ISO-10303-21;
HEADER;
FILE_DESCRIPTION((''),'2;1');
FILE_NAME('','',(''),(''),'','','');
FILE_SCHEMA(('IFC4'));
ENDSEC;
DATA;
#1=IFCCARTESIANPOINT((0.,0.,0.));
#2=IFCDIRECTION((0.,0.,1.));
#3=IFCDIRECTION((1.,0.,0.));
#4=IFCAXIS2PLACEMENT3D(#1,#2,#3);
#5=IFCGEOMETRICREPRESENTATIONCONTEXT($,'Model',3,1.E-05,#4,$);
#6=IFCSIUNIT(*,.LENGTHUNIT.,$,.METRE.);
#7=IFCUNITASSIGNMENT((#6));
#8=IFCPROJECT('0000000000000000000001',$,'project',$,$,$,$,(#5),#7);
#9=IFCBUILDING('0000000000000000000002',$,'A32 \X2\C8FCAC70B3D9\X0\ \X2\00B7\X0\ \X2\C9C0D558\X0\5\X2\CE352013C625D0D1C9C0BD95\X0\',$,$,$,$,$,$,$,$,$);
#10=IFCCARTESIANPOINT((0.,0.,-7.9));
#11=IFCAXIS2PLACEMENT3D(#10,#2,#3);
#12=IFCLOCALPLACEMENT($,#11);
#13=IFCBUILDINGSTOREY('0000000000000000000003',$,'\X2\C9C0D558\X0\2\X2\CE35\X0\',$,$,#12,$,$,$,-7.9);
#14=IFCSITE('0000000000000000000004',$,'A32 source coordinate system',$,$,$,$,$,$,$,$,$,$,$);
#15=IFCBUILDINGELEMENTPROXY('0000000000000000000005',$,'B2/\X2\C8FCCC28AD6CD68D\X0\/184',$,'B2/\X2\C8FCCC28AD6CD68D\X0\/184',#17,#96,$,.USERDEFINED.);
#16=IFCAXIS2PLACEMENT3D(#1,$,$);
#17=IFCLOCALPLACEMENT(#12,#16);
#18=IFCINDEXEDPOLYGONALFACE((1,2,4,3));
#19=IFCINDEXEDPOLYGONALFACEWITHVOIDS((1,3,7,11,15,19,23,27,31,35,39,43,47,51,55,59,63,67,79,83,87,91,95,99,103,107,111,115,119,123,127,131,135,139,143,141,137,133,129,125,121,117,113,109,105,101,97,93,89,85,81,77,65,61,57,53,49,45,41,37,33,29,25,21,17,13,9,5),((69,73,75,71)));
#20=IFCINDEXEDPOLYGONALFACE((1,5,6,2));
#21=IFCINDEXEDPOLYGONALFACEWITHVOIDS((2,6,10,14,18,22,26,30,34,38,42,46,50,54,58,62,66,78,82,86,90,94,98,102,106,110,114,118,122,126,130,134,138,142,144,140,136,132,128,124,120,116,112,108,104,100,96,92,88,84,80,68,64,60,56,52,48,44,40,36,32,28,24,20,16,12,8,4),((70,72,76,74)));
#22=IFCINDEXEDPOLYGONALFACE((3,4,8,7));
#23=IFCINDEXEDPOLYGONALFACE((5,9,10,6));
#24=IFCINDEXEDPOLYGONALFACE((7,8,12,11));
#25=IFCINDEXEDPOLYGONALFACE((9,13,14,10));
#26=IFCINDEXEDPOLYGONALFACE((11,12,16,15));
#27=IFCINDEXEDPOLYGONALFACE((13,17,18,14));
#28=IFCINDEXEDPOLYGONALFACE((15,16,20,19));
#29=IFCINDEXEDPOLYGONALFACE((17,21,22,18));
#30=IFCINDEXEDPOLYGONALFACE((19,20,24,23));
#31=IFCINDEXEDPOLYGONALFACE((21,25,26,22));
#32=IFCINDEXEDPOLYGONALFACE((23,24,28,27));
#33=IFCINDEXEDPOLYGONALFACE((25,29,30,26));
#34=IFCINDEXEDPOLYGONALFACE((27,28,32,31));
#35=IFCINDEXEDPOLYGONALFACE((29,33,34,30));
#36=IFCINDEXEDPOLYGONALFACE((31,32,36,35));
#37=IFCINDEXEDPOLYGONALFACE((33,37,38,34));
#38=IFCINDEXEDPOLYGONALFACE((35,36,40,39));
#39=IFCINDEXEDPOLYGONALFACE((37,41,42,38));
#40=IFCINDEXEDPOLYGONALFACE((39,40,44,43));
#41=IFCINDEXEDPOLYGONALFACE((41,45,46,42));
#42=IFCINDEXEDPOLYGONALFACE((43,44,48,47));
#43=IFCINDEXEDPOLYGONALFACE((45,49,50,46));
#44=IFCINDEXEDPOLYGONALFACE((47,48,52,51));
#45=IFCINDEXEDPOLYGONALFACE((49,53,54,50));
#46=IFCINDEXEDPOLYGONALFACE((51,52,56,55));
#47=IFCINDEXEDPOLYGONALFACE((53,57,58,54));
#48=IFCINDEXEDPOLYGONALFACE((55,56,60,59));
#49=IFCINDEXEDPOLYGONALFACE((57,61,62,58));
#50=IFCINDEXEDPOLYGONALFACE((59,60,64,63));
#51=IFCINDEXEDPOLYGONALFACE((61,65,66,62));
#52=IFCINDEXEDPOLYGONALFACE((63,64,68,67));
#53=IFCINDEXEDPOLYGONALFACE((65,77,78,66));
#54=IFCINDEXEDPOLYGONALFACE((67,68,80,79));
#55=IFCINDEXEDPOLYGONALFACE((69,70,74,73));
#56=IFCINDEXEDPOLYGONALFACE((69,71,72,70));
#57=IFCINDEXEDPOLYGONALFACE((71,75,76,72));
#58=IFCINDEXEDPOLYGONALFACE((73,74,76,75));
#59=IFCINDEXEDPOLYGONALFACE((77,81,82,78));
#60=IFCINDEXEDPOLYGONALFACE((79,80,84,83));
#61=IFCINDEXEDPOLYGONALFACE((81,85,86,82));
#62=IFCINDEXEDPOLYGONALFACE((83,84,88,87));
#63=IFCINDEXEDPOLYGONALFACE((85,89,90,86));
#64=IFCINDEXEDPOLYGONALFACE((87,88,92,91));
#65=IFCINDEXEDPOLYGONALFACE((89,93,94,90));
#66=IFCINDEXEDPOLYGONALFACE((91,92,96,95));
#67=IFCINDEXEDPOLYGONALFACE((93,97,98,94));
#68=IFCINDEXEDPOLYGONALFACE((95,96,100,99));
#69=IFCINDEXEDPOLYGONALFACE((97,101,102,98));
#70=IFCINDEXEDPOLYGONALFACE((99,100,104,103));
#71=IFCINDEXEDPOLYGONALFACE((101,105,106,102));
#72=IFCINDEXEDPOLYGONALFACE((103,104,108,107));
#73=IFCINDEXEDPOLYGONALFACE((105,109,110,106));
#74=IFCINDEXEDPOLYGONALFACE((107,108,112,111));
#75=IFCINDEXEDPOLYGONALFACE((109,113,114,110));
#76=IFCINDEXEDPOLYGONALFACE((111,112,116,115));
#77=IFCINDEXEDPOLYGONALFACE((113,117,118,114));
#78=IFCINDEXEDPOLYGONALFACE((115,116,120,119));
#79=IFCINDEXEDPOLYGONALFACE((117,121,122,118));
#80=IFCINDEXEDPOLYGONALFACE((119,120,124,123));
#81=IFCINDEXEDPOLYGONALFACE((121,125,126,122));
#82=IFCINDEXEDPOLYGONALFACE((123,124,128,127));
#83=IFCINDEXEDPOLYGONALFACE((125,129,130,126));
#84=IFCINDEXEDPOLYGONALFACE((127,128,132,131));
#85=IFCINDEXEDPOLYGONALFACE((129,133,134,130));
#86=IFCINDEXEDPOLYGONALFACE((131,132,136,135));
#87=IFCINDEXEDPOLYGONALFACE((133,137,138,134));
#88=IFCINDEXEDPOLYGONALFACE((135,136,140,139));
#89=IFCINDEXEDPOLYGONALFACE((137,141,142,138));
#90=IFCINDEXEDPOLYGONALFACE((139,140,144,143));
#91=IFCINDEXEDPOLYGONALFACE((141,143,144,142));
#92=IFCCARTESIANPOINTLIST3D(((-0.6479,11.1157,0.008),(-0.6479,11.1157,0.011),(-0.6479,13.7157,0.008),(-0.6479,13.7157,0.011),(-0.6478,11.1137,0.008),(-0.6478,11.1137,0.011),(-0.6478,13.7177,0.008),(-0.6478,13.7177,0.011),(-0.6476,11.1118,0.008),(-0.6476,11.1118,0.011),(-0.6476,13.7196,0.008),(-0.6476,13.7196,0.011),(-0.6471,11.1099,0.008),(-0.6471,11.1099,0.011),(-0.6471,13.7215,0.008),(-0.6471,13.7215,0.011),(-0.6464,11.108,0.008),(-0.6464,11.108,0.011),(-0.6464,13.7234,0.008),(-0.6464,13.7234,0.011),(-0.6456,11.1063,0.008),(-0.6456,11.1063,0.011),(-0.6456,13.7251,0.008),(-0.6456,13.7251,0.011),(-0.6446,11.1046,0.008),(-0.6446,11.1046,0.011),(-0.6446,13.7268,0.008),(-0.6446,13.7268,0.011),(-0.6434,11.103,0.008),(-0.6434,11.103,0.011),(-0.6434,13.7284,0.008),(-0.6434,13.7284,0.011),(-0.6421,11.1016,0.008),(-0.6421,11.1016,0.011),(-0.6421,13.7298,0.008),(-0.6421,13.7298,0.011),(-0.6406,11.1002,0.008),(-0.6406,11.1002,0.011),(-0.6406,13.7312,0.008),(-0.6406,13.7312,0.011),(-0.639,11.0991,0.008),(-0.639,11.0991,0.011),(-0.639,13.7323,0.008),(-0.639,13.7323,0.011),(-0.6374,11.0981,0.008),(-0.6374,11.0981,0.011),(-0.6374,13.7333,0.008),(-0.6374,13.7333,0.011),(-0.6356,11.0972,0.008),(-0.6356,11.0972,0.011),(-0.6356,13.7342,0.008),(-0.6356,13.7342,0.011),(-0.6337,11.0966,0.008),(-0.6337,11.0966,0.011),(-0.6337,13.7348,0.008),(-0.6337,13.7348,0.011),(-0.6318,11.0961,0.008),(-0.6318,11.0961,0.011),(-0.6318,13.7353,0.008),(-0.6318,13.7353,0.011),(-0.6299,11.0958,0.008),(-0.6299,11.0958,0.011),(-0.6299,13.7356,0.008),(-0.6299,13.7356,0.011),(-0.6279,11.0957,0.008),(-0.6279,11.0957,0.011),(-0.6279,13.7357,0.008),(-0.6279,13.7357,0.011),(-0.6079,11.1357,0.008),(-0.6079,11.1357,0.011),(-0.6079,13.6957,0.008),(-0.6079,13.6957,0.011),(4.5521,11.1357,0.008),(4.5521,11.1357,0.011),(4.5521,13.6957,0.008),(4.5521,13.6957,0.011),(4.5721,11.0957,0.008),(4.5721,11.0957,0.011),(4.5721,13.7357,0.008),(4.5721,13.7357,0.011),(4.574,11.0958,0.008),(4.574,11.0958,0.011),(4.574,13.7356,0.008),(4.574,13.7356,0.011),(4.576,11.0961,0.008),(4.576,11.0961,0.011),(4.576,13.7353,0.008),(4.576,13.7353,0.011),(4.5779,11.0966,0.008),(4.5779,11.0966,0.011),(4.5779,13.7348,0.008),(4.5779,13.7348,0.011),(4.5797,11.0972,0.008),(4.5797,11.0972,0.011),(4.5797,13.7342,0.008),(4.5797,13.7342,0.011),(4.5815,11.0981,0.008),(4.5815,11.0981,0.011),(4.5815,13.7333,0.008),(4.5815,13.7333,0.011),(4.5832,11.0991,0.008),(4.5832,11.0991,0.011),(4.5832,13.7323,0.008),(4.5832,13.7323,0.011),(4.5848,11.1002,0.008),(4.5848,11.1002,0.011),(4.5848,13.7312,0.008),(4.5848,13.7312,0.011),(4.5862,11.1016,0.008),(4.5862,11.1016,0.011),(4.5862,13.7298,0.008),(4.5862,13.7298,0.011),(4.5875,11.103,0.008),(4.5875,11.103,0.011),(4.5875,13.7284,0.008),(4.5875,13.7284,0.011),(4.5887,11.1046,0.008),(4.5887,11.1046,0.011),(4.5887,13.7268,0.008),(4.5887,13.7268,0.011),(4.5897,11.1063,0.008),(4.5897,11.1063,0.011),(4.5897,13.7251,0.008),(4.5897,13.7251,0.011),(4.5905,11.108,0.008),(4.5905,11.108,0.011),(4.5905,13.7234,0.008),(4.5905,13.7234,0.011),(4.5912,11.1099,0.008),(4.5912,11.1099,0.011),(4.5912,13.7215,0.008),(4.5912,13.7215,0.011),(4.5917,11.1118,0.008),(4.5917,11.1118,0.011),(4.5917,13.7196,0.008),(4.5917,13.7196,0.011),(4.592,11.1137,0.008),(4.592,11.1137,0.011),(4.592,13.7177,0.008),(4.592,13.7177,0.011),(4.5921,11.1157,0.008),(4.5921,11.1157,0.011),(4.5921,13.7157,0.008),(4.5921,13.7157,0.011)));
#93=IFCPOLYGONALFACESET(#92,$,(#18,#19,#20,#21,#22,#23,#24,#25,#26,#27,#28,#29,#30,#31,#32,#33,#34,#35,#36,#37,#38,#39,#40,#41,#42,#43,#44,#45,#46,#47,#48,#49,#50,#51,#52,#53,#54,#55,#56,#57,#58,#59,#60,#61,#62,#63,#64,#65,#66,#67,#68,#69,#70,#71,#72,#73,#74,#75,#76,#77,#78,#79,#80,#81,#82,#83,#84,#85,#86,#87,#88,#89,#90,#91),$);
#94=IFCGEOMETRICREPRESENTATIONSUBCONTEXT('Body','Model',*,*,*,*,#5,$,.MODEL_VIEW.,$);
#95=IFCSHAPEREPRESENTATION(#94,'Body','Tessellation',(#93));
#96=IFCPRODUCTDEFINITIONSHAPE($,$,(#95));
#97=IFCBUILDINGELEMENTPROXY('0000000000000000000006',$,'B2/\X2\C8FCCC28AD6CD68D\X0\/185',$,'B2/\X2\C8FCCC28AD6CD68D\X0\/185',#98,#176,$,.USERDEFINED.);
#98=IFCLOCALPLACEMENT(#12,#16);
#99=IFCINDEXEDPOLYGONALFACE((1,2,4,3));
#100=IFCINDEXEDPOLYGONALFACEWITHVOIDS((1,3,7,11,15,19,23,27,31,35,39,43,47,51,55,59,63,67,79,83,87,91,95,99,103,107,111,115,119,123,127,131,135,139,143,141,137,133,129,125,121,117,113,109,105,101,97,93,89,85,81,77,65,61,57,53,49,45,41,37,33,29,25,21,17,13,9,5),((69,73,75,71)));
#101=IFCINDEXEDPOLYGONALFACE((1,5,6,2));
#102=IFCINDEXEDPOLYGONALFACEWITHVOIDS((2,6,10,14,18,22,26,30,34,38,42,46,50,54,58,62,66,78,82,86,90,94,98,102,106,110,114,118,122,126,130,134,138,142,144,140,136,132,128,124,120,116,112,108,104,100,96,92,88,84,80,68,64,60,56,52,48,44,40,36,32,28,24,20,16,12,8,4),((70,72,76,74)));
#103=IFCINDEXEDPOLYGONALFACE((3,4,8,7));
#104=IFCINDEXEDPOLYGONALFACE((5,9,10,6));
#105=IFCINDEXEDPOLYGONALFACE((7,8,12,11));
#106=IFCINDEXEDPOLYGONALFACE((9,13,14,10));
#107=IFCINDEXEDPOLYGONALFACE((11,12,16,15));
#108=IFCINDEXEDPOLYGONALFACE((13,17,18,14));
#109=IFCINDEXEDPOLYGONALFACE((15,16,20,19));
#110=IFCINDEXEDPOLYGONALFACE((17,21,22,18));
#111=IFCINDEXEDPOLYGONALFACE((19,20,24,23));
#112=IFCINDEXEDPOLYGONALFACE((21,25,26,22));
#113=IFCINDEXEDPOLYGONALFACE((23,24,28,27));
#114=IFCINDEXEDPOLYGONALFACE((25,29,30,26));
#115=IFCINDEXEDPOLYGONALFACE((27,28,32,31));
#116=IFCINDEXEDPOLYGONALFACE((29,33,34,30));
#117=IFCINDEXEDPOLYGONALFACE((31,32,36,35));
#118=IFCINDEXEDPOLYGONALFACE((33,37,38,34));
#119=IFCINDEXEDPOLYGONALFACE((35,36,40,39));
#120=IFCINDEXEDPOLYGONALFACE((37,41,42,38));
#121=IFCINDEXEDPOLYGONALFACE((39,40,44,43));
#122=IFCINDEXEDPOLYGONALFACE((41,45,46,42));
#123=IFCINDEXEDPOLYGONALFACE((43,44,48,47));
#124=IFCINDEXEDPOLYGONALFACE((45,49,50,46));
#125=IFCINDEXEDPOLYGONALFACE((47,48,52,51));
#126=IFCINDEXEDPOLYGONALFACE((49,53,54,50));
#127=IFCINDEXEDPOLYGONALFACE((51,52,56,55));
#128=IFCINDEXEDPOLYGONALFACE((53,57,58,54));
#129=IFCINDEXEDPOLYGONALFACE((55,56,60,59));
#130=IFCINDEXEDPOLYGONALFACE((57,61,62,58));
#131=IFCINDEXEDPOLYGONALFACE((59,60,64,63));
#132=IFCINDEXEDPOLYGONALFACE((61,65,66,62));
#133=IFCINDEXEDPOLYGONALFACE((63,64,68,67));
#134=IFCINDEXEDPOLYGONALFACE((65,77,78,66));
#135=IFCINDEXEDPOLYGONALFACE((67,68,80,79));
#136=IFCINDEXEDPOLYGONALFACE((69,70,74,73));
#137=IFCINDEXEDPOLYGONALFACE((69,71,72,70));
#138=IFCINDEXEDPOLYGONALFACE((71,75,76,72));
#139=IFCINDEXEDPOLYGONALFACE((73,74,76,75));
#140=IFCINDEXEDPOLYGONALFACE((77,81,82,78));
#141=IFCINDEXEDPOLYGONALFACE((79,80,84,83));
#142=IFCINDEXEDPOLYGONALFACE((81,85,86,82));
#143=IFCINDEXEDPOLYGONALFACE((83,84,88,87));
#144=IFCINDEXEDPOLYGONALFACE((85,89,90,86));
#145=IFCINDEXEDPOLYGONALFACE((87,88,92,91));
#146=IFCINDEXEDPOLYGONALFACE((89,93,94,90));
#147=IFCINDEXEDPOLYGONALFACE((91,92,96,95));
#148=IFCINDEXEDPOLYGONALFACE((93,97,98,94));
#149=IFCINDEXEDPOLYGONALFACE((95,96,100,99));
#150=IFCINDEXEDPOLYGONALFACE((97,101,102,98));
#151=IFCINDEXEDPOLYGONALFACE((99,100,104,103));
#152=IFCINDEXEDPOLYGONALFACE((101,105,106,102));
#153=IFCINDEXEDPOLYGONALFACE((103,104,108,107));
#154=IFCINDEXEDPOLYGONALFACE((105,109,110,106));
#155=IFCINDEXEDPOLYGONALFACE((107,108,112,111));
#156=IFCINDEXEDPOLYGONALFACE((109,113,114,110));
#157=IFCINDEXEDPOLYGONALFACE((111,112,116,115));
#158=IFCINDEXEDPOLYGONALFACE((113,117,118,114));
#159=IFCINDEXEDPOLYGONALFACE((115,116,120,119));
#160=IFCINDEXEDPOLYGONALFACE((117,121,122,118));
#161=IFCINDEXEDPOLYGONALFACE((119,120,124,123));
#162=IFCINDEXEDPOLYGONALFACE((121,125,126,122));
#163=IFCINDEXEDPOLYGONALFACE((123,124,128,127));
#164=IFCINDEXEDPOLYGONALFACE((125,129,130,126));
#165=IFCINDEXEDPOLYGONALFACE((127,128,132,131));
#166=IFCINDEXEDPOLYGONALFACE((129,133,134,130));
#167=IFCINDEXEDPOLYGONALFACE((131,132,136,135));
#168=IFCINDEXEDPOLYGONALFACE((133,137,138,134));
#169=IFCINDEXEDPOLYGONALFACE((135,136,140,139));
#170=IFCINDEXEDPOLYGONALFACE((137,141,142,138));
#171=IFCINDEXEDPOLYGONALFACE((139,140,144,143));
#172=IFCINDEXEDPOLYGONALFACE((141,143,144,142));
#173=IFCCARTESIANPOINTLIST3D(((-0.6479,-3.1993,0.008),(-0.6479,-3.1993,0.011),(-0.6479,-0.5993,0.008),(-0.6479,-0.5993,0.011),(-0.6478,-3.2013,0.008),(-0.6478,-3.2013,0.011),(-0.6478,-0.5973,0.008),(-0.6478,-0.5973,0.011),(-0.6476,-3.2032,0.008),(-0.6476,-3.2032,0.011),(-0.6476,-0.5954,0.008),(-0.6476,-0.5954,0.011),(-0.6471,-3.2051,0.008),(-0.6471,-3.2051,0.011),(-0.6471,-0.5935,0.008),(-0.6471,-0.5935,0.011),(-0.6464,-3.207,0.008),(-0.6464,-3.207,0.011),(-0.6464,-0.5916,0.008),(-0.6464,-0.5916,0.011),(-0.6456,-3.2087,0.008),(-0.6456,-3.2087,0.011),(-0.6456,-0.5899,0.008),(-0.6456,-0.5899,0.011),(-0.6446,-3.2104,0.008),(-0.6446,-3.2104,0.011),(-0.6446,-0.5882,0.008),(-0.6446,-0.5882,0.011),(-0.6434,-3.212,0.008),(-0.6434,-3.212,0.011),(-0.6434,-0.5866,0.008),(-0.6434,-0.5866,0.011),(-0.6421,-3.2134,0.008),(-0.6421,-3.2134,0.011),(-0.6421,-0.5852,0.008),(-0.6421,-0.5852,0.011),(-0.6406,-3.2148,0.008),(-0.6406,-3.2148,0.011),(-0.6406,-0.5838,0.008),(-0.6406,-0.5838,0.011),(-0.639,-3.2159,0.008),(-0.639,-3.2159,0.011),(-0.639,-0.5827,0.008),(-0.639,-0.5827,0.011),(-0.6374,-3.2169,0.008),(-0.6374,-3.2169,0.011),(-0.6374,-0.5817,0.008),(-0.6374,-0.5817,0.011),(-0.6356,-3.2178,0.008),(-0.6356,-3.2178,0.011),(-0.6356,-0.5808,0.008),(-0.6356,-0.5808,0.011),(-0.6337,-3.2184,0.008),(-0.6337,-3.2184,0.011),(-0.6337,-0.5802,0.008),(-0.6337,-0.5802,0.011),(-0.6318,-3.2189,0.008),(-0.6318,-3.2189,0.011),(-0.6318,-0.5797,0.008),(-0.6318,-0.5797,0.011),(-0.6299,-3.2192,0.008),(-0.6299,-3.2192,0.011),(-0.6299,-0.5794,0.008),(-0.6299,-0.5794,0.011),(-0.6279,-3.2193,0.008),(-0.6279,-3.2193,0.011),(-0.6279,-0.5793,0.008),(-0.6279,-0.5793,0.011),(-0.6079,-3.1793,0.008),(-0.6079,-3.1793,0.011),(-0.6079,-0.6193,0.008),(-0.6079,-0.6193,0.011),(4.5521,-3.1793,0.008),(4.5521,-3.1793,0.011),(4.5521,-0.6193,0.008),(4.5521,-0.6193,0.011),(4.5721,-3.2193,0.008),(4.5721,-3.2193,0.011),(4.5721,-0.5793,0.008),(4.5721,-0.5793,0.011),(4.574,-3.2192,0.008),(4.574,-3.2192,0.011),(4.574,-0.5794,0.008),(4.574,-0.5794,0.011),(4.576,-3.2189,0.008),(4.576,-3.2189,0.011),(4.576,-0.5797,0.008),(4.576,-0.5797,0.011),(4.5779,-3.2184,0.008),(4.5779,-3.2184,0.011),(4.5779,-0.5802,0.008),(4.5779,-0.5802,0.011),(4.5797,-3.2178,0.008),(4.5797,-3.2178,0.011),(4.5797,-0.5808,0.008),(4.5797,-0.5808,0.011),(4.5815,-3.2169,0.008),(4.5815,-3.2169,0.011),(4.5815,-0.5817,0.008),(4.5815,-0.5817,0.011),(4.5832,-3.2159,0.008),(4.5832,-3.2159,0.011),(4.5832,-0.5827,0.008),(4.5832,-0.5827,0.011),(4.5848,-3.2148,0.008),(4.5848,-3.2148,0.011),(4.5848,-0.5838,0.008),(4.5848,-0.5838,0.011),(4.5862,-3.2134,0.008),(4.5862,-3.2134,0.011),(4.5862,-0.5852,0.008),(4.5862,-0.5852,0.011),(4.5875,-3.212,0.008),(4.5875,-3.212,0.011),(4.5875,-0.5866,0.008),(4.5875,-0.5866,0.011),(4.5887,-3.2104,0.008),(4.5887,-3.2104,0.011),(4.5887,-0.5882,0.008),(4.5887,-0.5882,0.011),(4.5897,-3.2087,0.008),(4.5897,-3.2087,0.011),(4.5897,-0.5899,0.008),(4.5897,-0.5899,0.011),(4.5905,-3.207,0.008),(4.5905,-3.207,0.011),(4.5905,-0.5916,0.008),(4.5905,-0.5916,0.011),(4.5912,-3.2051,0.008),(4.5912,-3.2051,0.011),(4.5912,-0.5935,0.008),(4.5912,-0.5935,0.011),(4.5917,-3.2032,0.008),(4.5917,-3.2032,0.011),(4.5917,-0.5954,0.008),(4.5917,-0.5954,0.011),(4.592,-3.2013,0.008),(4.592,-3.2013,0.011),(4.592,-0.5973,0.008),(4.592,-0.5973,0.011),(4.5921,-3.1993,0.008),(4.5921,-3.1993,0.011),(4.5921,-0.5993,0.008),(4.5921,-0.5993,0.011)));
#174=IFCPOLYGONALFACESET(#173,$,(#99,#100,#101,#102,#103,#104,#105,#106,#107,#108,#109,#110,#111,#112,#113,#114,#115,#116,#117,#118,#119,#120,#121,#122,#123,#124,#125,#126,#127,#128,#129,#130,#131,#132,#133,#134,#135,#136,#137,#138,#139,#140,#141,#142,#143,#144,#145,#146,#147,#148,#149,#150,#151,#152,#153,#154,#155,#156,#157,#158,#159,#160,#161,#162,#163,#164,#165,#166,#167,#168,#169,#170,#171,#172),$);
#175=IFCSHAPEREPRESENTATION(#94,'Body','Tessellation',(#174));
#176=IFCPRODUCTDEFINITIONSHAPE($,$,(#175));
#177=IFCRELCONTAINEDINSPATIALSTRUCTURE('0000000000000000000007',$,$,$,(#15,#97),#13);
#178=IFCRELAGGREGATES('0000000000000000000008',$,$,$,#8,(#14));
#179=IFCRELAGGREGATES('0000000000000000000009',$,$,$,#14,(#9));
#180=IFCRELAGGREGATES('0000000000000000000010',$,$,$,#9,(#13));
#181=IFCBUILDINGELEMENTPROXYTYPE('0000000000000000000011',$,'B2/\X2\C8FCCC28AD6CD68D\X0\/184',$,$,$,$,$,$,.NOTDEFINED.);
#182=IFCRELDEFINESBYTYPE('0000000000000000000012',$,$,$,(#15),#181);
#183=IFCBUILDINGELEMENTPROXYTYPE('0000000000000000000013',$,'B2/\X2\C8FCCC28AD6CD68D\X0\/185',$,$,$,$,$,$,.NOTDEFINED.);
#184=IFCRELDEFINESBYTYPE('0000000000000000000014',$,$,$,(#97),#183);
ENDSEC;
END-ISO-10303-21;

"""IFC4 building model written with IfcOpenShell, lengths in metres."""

from ifc_helpers import new_model, si_unit, frame, origin, origin_with_axes, place, context, subcontext, project, spatial, polyline, outline, extrude, source, transform, mapped, type_object, type_shapes, element, save


model = new_model("IFC4")

# Units and contexts
model_context = context("Model", 3, precision=1e-05, world=origin_with_axes())
body_context = subcontext(model_context, "Body", "Model", "MODEL_VIEW")
ifc_project = project(units=[si_unit("LENGTHUNIT", "METRE")], contexts=[model_context])

# Site, building, storey
site = spatial("IfcSite", under=ifc_project, Name="A32 source coordinate system")
building = spatial("IfcBuilding", under=site, Name="A32 주거동 · 지하5층–옥탑지붕")
storey_placement = place(None, frame((0.0, 0.0, -7.9), z_axis=(0.0, 0.0, 1.0), x_axis=(1.0, 0.0, 0.0)))
storey = spatial("IfcBuildingStorey", under=building, at=storey_placement, Name="지하2층", Elevation=-7.9)

# Building element proxies
building_element_proxy_type_1 = type_object("IfcBuildingElementProxyType", Name="B2/주차구획/184", PredefinedType="NOTDEFINED")
shared_shape_1 = source(origin(), body_context, "Body", "SweptSolid", [
    extrude(outline(polyline([(4.5921, 11.1157), (4.592, 11.1137), (4.5917, 11.1118), (4.5912, 11.1099), (4.5905, 11.108), (4.5897, 11.1063), (4.5887, 11.1046), (4.5875, 11.103), (4.5862, 11.1016), (4.5848, 11.1002), (4.5832, 11.0991), (4.5815, 11.0981), (4.5797, 11.0972), (4.5779, 11.0966), (4.576, 11.0961), (4.574, 11.0958), (4.5721, 11.0957), (-0.6279, 11.0957), (-0.6299, 11.0958), (-0.6318, 11.0961), (-0.6337, 11.0966), (-0.6356, 11.0972), (-0.6374, 11.0981), (-0.639, 11.0991), (-0.6406, 11.1002), (-0.6421, 11.1016), (-0.6434, 11.103), (-0.6446, 11.1046), (-0.6456, 11.1063), (-0.6464, 11.108), (-0.6471, 11.1099), (-0.6476, 11.1118), (-0.6478, 11.1137), (-0.6479, 11.1157), (-0.6479, 13.7157), (-0.6478, 13.7177), (-0.6476, 13.7196), (-0.6471, 13.7215), (-0.6464, 13.7234), (-0.6456, 13.7251), (-0.6446, 13.7268), (-0.6434, 13.7284), (-0.6421, 13.7298), (-0.6406, 13.7312), (-0.639, 13.7323), (-0.6374, 13.7333), (-0.6356, 13.7342), (-0.6337, 13.7348), (-0.6318, 13.7353), (-0.6299, 13.7356), (-0.6279, 13.7357), (4.5721, 13.7357), (4.574, 13.7356), (4.576, 13.7353), (4.5779, 13.7348), (4.5797, 13.7342), (4.5815, 13.7333), (4.5832, 13.7323), (4.5848, 13.7312), (4.5862, 13.7298), (4.5875, 13.7284), (4.5887, 13.7268), (4.5897, 13.7251), (4.5905, 13.7234), (4.5912, 13.7215), (4.5917, 13.7196), (4.592, 13.7177), (4.5921, 13.7157), (4.5921, 11.1157)]), holes=[polyline([(4.5521, 11.1357), (4.5521, 13.6957), (-0.6079, 13.6957), (-0.6079, 11.1357), (4.5521, 11.1357)])]), frame((0.0, 0.0, 0.008)), (0.0, 0.0, 1.0), 0.003),
])
type_shapes(building_element_proxy_type_1, [shared_shape_1])
proxy_1_placement = place(storey_placement, origin_with_axes())
element("IfcBuildingElementProxy", 1, at=proxy_1_placement, inside=storey, type_object=building_element_proxy_type_1, Name="B2/주차구획/184", ObjectType="B2/주차구획/184", PredefinedType="USERDEFINED", context=body_context, shape_type="MappedRepresentation", body=[
    mapped(shared_shape_1, transform((0.0, 0.0, 0.0), scale=1.0)),
])
building_element_proxy_type_2 = type_object("IfcBuildingElementProxyType", Name="B2/주차구획/185", PredefinedType="NOTDEFINED")
shared_shape_2 = source(origin(), body_context, "Body", "SweptSolid", [
    extrude(outline(polyline([(4.5921, -3.1993), (4.592, -3.2013), (4.5917, -3.2032), (4.5912, -3.2051), (4.5905, -3.207), (4.5897, -3.2087), (4.5887, -3.2104), (4.5875, -3.212), (4.5862, -3.2134), (4.5848, -3.2148), (4.5832, -3.2159), (4.5815, -3.2169), (4.5797, -3.2178), (4.5779, -3.2184), (4.576, -3.2189), (4.574, -3.2192), (4.5721, -3.2193), (-0.6279, -3.2193), (-0.6299, -3.2192), (-0.6318, -3.2189), (-0.6337, -3.2184), (-0.6356, -3.2178), (-0.6374, -3.2169), (-0.639, -3.2159), (-0.6406, -3.2148), (-0.6421, -3.2134), (-0.6434, -3.212), (-0.6446, -3.2104), (-0.6456, -3.2087), (-0.6464, -3.207), (-0.6471, -3.2051), (-0.6476, -3.2032), (-0.6478, -3.2013), (-0.6479, -3.1993), (-0.6479, -0.5993), (-0.6478, -0.5973), (-0.6476, -0.5954), (-0.6471, -0.5935), (-0.6464, -0.5916), (-0.6456, -0.5899), (-0.6446, -0.5882), (-0.6434, -0.5866), (-0.6421, -0.5852), (-0.6406, -0.5838), (-0.639, -0.5827), (-0.6374, -0.5817), (-0.6356, -0.5808), (-0.6337, -0.5802), (-0.6318, -0.5797), (-0.6299, -0.5794), (-0.6279, -0.5793), (4.5721, -0.5793), (4.574, -0.5794), (4.576, -0.5797), (4.5779, -0.5802), (4.5797, -0.5808), (4.5815, -0.5817), (4.5832, -0.5827), (4.5848, -0.5838), (4.5862, -0.5852), (4.5875, -0.5866), (4.5887, -0.5882), (4.5897, -0.5899), (4.5905, -0.5916), (4.5912, -0.5935), (4.5917, -0.5954), (4.592, -0.5973), (4.5921, -0.5993), (4.5921, -3.1993)]), holes=[polyline([(4.5521, -3.1793), (4.5521, -0.6193), (-0.6079, -0.6193), (-0.6079, -3.1793), (4.5521, -3.1793)])]), frame((0.0, 0.0, 0.008)), (0.0, 0.0, 1.0), 0.003),
])
type_shapes(building_element_proxy_type_2, [shared_shape_2])
proxy_2_placement = place(storey_placement, origin_with_axes())
element("IfcBuildingElementProxy", 2, at=proxy_2_placement, inside=storey, type_object=building_element_proxy_type_2, Name="B2/주차구획/185", ObjectType="B2/주차구획/185", PredefinedType="USERDEFINED", context=body_context, shape_type="MappedRepresentation", body=[
    mapped(shared_shape_2, transform((0.0, 0.0, 0.0), scale=1.0)),
])

save(model, "model.ifc")
